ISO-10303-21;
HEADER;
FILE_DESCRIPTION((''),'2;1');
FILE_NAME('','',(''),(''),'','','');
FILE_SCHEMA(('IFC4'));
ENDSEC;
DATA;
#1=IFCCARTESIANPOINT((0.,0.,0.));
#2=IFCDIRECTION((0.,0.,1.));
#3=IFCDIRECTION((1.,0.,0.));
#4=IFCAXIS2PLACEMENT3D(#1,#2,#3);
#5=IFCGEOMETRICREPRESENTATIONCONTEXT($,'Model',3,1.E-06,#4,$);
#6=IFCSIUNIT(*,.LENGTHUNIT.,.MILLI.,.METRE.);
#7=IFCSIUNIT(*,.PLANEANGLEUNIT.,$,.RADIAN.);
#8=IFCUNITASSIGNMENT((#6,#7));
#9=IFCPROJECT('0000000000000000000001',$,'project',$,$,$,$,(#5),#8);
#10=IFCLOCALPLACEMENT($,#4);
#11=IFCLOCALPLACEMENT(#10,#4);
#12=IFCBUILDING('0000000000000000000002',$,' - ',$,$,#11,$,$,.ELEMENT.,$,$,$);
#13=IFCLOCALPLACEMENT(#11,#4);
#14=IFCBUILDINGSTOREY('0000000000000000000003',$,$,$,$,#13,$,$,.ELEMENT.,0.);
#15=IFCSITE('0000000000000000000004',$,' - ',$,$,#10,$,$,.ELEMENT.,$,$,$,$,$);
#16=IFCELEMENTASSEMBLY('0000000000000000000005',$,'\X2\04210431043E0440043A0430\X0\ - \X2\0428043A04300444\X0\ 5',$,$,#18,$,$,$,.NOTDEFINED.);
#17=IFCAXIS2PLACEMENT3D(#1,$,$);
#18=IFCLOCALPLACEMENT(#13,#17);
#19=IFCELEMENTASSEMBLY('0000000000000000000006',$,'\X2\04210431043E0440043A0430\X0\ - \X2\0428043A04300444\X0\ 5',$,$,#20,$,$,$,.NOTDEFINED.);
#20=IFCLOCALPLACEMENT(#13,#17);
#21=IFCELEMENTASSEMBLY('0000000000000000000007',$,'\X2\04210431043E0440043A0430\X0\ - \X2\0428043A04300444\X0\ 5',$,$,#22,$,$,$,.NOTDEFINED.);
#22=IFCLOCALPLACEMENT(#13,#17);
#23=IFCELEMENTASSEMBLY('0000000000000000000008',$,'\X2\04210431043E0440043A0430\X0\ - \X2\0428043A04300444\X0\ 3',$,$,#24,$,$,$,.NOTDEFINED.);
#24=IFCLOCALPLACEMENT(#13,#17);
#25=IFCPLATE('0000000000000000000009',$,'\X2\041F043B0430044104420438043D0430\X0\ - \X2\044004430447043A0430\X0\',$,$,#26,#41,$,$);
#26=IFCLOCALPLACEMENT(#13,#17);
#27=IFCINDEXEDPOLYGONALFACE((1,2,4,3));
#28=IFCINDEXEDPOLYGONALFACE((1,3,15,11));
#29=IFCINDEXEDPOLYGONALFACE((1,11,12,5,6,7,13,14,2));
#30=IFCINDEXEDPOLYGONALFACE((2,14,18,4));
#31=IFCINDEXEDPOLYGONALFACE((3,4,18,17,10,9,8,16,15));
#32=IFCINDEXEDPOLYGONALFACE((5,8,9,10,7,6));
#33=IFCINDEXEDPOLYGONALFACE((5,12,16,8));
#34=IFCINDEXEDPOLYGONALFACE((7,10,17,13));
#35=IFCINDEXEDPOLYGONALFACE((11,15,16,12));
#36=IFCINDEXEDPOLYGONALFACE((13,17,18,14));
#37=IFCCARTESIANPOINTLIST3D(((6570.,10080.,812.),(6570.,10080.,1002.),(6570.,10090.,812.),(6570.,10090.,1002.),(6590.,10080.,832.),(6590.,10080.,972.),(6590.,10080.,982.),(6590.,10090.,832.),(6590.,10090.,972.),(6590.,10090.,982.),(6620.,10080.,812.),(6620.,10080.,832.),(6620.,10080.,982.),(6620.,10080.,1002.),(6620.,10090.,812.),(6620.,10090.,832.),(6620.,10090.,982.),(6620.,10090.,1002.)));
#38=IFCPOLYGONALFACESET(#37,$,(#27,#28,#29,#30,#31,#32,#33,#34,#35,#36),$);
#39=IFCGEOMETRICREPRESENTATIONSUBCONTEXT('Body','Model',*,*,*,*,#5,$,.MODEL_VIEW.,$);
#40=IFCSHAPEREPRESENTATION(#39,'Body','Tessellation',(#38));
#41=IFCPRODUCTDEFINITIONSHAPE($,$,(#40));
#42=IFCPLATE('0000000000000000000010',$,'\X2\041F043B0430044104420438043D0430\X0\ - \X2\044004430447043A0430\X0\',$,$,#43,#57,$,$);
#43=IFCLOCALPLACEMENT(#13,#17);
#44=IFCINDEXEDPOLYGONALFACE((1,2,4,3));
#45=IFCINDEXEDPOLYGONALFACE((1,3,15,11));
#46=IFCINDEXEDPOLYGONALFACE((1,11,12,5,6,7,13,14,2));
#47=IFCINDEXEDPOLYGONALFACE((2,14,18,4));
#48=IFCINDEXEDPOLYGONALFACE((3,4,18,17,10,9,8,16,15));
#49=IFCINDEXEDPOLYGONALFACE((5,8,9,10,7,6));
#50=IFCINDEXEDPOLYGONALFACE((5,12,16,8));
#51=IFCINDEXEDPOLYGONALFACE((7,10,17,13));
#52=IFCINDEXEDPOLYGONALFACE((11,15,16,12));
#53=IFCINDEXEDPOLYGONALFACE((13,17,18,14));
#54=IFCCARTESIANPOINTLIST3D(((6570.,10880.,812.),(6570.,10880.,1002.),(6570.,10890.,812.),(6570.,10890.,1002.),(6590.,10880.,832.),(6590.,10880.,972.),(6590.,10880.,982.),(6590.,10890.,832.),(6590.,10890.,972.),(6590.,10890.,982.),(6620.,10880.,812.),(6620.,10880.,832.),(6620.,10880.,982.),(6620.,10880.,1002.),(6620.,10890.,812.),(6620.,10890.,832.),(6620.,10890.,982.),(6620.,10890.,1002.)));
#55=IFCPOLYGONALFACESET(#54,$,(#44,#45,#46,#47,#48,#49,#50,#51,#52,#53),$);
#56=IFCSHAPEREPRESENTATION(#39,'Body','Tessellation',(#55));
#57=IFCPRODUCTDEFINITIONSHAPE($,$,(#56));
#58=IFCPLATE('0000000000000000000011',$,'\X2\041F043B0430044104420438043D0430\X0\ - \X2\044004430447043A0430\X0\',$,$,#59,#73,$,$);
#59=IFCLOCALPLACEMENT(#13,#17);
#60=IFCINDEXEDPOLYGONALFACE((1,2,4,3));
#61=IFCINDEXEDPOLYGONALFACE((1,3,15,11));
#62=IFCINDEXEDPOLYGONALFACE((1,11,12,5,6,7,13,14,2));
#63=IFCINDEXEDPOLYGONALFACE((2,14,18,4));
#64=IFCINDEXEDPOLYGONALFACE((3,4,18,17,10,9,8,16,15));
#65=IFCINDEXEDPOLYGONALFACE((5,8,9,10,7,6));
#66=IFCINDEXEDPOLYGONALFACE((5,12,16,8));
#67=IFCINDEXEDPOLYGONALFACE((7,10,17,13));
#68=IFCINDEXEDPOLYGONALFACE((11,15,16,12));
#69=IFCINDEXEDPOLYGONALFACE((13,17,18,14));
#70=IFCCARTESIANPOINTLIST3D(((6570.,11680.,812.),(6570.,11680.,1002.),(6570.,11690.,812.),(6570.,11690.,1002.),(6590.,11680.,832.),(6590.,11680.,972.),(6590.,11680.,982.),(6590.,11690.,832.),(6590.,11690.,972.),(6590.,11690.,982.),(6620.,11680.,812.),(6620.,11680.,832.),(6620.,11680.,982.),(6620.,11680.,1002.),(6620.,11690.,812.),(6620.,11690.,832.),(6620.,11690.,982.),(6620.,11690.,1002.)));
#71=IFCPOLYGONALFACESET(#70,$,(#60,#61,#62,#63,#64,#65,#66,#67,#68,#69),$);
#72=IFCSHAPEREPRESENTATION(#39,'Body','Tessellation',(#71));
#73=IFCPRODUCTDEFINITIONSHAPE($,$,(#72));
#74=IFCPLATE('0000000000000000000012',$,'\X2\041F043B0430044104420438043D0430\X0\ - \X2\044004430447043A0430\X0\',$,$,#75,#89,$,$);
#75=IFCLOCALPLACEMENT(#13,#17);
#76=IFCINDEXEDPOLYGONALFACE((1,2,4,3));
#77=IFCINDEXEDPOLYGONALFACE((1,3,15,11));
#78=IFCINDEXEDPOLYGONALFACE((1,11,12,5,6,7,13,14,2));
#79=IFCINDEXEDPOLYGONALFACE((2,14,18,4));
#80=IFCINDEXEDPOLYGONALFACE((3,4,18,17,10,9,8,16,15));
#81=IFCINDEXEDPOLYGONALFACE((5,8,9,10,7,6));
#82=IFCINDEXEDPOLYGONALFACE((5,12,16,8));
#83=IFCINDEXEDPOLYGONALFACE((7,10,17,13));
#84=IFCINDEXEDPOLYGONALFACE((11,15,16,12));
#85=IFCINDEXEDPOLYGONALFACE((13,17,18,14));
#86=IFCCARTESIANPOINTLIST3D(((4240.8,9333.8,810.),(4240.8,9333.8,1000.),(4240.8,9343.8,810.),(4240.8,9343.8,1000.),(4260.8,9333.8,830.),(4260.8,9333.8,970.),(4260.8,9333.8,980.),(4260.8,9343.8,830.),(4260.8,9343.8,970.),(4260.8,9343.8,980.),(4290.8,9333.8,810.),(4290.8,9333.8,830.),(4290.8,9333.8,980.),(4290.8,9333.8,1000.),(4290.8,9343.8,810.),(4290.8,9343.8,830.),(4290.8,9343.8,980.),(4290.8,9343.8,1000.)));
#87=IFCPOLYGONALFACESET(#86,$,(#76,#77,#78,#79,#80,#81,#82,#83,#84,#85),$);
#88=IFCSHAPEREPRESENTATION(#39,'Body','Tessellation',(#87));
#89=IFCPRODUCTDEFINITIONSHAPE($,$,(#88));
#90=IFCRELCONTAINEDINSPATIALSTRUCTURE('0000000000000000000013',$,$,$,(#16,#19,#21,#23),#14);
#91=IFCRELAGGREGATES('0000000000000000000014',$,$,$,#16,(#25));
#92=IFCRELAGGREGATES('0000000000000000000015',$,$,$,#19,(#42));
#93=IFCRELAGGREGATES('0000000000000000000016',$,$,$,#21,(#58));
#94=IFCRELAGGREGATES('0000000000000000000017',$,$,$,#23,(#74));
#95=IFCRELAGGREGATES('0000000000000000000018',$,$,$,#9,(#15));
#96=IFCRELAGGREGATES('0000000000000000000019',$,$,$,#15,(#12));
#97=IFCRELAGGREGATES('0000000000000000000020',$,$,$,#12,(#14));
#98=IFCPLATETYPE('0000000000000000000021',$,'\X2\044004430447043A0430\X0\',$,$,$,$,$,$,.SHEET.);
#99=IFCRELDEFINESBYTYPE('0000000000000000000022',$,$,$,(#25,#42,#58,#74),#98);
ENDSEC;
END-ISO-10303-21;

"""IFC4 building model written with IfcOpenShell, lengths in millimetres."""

from ifc_helpers import new_model, si_unit, frame, origin_with_axes, place, context, subcontext, project, spatial, line, indexed_curve, outline, extrude, source, transform, mapped, type_object, element, aggregate, save


model = new_model("IFC4")

# Units and contexts
model_context = context("Model", 3, precision=1e-06, world=origin_with_axes())
body_context = subcontext(model_context, "Body", "Model", "MODEL_VIEW")
ifc_project = project(units=[si_unit("LENGTHUNIT", "METRE", prefix="MILLI"), si_unit("PLANEANGLEUNIT", "RADIAN")], contexts=[model_context])

# Site, building, storey
site_placement = place(None, origin_with_axes())
site = spatial("IfcSite", under=ifc_project, at=site_placement, Name=" - ", CompositionType="ELEMENT")
building_placement = place(site_placement, origin_with_axes())
building = spatial("IfcBuilding", under=site, at=building_placement, Name=" - ", CompositionType="ELEMENT")
storey_placement = place(building_placement, origin_with_axes())
storey = spatial("IfcBuildingStorey", under=building, at=storey_placement, CompositionType="ELEMENT", Elevation=0.0)

# Shared definitions
plate_type = type_object("IfcPlateType", Name="ручка", PredefinedType="SHEET")

# Element assemblies
assembly_1_placement = place(storey_placement, frame((6620.0, 10450.0, 2.0), z_axis=(0.0, 0.0, 1.0), x_axis=(0.0, -1.0, 0.0)))
assembly_1 = element("IfcElementAssembly", 1, at=assembly_1_placement, inside=storey, Name="Сборка - Шкаф 5", PredefinedType="NOTDEFINED")
assembly_2_placement = place(storey_placement, frame((6620.0, 11250.0, 2.0), z_axis=(0.0, 0.0, 1.0), x_axis=(0.0, -1.0, 0.0)))
assembly_2 = element("IfcElementAssembly", 2, at=assembly_2_placement, inside=storey, Name="Сборка - Шкаф 5", PredefinedType="NOTDEFINED")
assembly_3_placement = place(storey_placement, frame((6620.0, 12050.0, 2.0), z_axis=(0.0, 0.0, 1.0), x_axis=(0.0, -1.0, 0.0)))
assembly_3 = element("IfcElementAssembly", 3, at=assembly_3_placement, inside=storey, Name="Сборка - Шкаф 5", PredefinedType="NOTDEFINED")
assembly_4_placement = place(storey_placement, frame((4290.8, 9903.8, 0.0), z_axis=(0.0, 0.0, 1.0), x_axis=(0.0, -1.0, 0.0)))
assembly_4 = element("IfcElementAssembly", 4, at=assembly_4_placement, inside=storey, Name="Сборка - Шкаф 3", PredefinedType="NOTDEFINED")
shared_shape_1 = source(origin_with_axes(), body_context, "Body", "SweptSolid", [
    extrude(outline(indexed_curve([(-95.0, -25.0), (-75.0, -25.0), (-75.0, 5.0), (-65.0, 5.0), (75.0, 5.0), (75.0, -25.0), (95.0, -25.0), (95.0, 25.0), (-95.0, 25.0)], segments=[line(1, 2), line(2, 3), line(3, 4), line(4, 5), line(5, 6), line(6, 7), line(7, 8), line(8, 9), line(9, 1)])), origin_with_axes(), (0.0, 0.0, 1.0), 10.0),
])

# Plates
plate_1_placement = place(assembly_1_placement, frame((370.0, -25.0, 905.0), z_axis=(-1.0, 0.0, 0.0), x_axis=(0.0, 0.0, -1.0)))
plate_1 = element("IfcPlate", 5, at=plate_1_placement, type_object=plate_type, Name="Пластина - ручка", context=body_context, shape_type="MappedRepresentation", body=[
    mapped(shared_shape_1, transform((0.0, 0.0, 0.0), x_axis=(1.0, 0.0, 0.0), y_axis=(0.0, 1.0, 0.0), z_axis=(0.0, 0.0, 1.0), scale=1.0)),
])
aggregate(assembly_1, [plate_1])
plate_2_placement = place(assembly_2_placement, frame((370.0, -25.0, 905.0), z_axis=(-1.0, 0.0, 0.0), x_axis=(0.0, 0.0, -1.0)))
plate_2 = element("IfcPlate", 6, at=plate_2_placement, type_object=plate_type, Name="Пластина - ручка", context=body_context, shape_type="MappedRepresentation", body=[
    mapped(shared_shape_1, transform((0.0, 0.0, 0.0), x_axis=(1.0, 0.0, 0.0), y_axis=(0.0, 1.0, 0.0), z_axis=(0.0, 0.0, 1.0), scale=1.0)),
])
aggregate(assembly_2, [plate_2])
plate_3_placement = place(assembly_3_placement, frame((370.0, -25.0, 905.0), z_axis=(-1.0, 0.0, 0.0), x_axis=(0.0, 0.0, -1.0)))
plate_3 = element("IfcPlate", 7, at=plate_3_placement, type_object=plate_type, Name="Пластина - ручка", context=body_context, shape_type="MappedRepresentation", body=[
    mapped(shared_shape_1, transform((0.0, 0.0, 0.0), x_axis=(1.0, 0.0, 0.0), y_axis=(0.0, 1.0, 0.0), z_axis=(0.0, 0.0, 1.0), scale=1.0)),
])
aggregate(assembly_3, [plate_3])
plate_4_placement = place(assembly_4_placement, frame((570.0, -25.0, 905.0), z_axis=(-1.0, 0.0, 0.0), x_axis=(0.0, 0.0, -1.0)))
plate_4 = element("IfcPlate", 8, at=plate_4_placement, type_object=plate_type, Name="Пластина - ручка", context=body_context, shape_type="MappedRepresentation", body=[
    mapped(shared_shape_1, transform((0.0, 0.0, 0.0), x_axis=(1.0, 0.0, 0.0), y_axis=(0.0, 1.0, 0.0), z_axis=(0.0, 0.0, 1.0), scale=1.0)),
])
aggregate(assembly_4, [plate_4])

save(model, "model.ifc")
